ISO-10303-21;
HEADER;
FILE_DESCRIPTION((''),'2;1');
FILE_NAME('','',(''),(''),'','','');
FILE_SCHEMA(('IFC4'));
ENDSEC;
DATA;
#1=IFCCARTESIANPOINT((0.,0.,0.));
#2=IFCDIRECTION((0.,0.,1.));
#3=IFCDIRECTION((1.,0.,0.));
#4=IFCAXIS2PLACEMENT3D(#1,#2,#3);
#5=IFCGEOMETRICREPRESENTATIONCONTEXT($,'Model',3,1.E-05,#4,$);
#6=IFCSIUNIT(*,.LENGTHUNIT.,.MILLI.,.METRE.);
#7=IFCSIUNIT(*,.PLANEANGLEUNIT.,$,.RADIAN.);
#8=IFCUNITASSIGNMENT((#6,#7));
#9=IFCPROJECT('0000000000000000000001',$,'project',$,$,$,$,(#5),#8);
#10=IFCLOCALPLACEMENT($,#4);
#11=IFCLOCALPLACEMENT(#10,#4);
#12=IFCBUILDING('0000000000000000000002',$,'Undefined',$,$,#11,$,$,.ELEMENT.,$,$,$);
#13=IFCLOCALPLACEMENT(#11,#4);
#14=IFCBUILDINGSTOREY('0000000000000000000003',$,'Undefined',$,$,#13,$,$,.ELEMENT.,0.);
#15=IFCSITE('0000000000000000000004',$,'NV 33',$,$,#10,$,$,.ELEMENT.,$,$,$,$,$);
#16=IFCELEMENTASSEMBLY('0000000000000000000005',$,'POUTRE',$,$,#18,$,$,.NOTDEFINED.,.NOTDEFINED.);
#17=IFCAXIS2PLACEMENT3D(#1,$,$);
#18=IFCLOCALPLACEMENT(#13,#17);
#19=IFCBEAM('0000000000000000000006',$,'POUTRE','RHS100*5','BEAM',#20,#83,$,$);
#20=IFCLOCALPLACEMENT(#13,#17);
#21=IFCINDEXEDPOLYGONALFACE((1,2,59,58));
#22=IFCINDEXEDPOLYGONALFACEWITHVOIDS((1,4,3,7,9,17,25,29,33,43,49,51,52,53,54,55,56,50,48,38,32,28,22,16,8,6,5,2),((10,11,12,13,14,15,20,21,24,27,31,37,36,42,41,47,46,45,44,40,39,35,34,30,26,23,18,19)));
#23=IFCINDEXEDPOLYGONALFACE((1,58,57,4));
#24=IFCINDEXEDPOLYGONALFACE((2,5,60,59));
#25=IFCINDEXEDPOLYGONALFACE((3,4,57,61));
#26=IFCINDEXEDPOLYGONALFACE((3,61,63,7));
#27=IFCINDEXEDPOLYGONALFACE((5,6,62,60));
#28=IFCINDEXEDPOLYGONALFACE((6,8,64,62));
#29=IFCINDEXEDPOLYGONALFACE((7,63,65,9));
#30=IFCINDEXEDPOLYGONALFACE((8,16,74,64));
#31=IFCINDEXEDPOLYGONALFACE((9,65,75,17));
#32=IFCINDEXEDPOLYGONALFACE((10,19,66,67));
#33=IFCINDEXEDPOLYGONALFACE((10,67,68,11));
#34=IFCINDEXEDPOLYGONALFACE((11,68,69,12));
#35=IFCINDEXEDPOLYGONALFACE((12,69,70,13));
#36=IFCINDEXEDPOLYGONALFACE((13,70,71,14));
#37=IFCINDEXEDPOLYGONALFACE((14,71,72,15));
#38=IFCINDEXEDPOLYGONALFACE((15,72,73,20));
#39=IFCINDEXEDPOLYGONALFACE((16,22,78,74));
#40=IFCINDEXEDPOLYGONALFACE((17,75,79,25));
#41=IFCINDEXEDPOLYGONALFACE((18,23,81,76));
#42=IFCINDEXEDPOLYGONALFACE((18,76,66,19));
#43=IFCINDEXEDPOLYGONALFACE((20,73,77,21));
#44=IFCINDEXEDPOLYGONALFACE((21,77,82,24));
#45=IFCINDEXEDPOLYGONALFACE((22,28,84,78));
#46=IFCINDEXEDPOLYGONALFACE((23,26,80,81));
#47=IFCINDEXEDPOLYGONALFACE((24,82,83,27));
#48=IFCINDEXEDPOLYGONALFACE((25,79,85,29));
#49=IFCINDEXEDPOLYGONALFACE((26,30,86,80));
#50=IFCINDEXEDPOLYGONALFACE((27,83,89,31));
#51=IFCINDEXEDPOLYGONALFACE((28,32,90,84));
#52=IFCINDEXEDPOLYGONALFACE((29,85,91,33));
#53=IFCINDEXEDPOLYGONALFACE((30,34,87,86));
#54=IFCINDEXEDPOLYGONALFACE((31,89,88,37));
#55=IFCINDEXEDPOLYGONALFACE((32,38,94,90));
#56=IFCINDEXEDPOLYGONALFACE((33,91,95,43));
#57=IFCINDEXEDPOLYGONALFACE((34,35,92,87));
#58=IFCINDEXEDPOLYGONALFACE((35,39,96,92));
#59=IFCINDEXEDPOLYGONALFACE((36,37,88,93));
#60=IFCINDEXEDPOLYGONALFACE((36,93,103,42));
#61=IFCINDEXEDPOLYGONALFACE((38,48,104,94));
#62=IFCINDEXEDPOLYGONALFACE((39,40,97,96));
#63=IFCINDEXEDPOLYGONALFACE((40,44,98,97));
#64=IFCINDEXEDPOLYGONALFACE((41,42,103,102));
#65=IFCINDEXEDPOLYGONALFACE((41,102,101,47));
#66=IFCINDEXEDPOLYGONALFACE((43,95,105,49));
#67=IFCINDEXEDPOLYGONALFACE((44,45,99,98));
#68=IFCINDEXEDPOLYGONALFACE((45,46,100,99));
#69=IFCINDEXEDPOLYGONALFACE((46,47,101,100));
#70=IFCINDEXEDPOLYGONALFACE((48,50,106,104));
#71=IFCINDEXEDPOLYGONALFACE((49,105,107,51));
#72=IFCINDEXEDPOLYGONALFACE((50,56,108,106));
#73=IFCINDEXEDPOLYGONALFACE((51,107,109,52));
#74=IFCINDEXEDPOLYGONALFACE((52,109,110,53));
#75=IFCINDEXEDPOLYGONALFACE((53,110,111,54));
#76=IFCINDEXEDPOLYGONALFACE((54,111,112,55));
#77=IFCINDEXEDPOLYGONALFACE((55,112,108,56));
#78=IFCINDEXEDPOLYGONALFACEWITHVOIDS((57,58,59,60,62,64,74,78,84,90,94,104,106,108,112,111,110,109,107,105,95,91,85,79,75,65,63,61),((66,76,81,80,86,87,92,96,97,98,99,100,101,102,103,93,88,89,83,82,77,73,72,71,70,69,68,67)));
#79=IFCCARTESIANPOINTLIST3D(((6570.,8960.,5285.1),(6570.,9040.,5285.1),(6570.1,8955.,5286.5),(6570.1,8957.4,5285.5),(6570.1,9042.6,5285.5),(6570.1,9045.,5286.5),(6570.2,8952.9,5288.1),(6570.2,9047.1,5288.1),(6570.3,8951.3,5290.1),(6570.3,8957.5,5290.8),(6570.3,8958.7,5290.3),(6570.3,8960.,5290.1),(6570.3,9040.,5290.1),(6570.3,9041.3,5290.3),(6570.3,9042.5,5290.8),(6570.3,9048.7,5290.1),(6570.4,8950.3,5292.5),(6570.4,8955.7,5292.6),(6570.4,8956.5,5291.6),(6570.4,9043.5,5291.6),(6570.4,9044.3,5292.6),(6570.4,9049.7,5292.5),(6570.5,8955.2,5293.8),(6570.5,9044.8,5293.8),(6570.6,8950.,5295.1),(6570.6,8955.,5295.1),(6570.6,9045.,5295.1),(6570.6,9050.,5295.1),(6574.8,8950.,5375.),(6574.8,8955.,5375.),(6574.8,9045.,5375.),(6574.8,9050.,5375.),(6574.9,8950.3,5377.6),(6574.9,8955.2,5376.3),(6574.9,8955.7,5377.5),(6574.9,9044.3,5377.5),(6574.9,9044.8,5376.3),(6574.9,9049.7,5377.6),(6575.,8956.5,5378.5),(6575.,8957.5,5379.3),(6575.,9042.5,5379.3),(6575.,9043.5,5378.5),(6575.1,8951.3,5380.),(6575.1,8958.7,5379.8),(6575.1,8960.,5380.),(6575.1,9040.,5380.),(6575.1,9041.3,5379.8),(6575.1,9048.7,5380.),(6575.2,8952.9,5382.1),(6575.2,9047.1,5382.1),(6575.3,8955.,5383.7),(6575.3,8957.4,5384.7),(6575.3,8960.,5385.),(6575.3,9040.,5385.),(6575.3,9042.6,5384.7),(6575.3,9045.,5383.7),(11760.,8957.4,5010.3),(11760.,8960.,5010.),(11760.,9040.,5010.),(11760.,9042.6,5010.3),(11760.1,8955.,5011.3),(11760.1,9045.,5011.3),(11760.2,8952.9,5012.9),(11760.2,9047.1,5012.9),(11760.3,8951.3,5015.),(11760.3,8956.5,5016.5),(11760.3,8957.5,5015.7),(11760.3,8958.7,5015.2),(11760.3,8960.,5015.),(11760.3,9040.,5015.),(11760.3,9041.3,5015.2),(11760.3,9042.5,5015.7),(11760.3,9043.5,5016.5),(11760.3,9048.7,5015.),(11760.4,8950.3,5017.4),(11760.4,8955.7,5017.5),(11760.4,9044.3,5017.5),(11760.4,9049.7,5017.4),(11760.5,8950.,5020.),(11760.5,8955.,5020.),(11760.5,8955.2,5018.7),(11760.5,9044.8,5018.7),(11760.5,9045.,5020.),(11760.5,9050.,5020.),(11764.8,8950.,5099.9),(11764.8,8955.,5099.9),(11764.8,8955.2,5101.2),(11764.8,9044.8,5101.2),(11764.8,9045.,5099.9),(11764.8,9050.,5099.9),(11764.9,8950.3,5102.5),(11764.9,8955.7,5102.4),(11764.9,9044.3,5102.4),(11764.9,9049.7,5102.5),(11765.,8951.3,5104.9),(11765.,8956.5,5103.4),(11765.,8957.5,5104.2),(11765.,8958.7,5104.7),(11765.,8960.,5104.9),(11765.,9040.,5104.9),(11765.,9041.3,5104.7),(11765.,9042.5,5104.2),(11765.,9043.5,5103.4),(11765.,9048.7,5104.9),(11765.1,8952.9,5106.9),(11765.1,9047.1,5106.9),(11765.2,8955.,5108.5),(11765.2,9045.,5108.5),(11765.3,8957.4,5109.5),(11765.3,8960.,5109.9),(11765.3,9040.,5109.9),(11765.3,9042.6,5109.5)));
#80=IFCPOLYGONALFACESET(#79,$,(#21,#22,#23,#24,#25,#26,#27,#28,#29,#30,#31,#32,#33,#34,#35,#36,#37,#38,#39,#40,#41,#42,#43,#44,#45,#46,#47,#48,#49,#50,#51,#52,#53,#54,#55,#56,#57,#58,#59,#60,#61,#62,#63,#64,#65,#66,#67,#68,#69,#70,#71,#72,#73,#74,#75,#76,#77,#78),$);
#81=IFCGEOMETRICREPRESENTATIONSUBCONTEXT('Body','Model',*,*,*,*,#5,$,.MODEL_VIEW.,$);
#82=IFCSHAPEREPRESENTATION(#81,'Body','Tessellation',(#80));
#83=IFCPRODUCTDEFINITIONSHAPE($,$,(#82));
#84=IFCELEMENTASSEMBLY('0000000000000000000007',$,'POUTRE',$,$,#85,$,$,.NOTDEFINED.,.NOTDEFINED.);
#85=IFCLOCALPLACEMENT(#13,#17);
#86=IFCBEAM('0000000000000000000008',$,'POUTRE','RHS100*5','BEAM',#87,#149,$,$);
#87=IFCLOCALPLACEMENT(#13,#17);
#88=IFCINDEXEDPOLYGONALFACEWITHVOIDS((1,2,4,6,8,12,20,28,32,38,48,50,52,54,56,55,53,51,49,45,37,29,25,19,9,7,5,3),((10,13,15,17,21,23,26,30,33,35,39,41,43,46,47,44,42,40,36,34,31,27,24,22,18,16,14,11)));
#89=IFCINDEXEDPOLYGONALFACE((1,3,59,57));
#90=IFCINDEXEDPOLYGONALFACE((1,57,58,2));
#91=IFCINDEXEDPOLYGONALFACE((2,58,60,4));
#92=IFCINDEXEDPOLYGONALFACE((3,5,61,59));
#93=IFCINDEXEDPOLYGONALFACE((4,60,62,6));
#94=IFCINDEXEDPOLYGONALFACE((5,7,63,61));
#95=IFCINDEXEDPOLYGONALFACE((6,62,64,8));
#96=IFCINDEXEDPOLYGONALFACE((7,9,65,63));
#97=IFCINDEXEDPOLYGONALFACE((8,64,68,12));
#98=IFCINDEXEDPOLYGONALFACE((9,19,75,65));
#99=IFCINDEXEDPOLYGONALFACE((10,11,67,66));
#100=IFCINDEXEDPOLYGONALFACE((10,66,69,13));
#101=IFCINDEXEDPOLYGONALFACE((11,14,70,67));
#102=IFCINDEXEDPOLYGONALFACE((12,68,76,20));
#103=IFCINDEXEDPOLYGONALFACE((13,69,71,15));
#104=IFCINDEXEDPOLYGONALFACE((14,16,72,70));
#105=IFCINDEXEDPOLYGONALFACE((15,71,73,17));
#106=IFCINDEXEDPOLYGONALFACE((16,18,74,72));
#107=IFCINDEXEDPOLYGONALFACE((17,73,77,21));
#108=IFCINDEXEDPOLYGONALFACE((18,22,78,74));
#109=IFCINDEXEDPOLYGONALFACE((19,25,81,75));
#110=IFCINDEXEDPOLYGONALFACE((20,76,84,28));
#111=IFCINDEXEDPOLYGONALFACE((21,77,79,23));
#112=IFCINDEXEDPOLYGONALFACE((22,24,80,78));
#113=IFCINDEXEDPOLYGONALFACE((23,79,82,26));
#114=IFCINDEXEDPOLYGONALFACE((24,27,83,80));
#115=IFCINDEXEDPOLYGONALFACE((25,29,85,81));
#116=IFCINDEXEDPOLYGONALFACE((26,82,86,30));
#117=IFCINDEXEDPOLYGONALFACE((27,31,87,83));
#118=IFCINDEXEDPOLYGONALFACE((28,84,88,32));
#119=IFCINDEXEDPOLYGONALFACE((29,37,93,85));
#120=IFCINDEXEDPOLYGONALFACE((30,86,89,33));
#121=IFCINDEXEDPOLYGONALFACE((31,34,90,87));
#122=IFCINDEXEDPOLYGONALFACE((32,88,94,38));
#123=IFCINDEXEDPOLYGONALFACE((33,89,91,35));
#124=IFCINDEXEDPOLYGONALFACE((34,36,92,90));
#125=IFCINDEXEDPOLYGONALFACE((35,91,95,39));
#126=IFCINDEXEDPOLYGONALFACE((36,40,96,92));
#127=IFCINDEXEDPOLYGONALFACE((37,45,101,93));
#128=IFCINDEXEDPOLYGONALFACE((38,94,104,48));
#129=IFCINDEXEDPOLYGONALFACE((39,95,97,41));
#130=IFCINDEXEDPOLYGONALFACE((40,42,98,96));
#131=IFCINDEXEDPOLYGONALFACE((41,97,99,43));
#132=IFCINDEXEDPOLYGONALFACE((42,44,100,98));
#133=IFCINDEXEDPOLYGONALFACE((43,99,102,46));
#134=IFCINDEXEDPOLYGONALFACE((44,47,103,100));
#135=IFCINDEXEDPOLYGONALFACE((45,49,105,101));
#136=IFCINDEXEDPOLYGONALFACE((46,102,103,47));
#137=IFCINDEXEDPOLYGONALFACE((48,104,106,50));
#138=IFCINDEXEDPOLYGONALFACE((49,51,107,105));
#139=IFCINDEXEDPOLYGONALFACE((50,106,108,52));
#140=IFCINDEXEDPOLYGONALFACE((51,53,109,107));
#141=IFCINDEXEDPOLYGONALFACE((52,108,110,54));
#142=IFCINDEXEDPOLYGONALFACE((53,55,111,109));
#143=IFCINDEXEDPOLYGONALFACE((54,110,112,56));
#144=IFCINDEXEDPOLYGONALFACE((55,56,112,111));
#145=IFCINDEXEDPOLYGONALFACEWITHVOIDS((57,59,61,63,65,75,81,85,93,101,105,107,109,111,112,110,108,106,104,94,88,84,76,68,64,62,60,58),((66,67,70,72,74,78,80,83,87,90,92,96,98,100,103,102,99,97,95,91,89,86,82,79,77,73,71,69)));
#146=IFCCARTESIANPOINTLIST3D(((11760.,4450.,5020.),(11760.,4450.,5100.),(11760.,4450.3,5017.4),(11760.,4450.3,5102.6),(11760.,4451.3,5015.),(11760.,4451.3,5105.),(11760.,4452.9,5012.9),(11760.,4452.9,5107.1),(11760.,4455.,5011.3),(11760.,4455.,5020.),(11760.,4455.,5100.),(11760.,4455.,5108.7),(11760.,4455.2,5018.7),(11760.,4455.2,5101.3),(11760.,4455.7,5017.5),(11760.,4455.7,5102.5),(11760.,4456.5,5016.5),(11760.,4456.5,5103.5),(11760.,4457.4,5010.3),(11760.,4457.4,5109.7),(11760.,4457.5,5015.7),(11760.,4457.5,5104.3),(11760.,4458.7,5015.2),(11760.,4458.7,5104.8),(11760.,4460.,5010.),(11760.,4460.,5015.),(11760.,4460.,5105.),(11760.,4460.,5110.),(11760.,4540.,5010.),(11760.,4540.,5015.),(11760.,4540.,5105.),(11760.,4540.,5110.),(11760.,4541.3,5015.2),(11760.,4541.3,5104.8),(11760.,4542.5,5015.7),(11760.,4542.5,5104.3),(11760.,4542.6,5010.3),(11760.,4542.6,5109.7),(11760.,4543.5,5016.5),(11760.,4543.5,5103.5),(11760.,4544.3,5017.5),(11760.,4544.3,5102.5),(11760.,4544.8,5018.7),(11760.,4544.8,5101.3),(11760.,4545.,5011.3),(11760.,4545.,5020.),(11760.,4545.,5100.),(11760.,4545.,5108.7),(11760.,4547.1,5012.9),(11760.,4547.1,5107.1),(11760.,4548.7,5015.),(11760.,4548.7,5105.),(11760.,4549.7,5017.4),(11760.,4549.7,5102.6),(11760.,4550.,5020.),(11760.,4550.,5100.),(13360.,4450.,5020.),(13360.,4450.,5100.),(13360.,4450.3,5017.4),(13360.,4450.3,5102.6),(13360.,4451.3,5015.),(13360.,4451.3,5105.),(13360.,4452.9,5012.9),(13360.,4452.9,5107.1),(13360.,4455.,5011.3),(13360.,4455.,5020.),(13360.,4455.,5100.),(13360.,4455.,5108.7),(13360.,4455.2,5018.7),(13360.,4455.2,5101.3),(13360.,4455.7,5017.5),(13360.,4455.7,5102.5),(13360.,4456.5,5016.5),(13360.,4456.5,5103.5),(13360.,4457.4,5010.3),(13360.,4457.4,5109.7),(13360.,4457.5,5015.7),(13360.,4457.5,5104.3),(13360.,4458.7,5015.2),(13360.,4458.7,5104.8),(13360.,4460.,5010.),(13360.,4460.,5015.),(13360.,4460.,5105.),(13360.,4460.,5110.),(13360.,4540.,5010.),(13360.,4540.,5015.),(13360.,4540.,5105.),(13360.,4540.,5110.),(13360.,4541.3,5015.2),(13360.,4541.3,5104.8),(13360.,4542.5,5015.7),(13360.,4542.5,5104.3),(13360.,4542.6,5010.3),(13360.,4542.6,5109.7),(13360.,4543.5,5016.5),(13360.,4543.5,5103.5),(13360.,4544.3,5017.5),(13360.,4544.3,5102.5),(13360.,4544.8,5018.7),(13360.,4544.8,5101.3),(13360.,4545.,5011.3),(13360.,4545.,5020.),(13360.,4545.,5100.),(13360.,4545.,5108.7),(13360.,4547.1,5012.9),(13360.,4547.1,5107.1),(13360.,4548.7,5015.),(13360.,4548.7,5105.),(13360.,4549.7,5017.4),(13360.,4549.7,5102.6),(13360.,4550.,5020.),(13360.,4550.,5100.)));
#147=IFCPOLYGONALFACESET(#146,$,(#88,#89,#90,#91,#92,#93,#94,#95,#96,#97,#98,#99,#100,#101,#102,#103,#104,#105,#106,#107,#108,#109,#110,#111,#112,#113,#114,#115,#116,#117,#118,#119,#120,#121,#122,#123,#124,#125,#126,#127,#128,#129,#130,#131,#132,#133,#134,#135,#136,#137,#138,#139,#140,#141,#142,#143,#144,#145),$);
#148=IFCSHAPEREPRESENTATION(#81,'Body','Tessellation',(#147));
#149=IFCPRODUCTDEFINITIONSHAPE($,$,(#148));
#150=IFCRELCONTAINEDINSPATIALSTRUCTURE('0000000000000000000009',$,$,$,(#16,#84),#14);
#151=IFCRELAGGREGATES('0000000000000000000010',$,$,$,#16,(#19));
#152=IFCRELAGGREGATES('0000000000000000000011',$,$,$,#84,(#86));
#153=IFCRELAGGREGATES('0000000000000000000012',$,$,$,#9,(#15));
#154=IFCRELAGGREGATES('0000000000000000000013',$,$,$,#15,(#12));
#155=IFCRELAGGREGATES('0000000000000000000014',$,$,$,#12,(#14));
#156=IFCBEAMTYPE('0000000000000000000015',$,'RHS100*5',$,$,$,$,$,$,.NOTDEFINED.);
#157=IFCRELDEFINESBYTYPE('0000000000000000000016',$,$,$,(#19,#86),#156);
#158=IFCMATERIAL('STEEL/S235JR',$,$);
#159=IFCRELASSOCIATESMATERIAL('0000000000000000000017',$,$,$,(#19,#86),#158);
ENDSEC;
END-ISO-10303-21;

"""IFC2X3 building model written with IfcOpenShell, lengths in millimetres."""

from ifc_helpers import new_model, si_unit, frame, origin_with_axes, origin_2d_with_axis, place, context, subcontext, project, spatial, hollow_rectangle, extrude, boolean, halfspace, material, type_object, element, aggregate, save


model = new_model("IFC2X3")

# Units and contexts
model_context = context("Model", 3, precision=1e-05, world=origin_with_axes())
body_context = subcontext(model_context, "Body", "Model", "MODEL_VIEW")
ifc_project = project(units=[si_unit("LENGTHUNIT", "METRE", prefix="MILLI"), si_unit("PLANEANGLEUNIT", "RADIAN")], contexts=[model_context])

# Site, building, storey
site_placement = place(None, origin_with_axes())
site = spatial("IfcSite", under=ifc_project, at=site_placement, Name="NV 33", CompositionType="ELEMENT")
building_placement = place(site_placement, origin_with_axes())
building = spatial("IfcBuilding", under=site, at=building_placement, Name="Undefined", CompositionType="ELEMENT")
storey_placement = place(building_placement, origin_with_axes())
storey = spatial("IfcBuildingStorey", under=building, at=storey_placement, Name="Undefined", CompositionType="ELEMENT", Elevation=0.0)

# Shared definitions
ifc_material_1 = material(Name="STEEL/S235JR")

# Element assemblies, beams
assembly_1_placement = place(storey_placement, origin_with_axes())
assembly_1 = element("IfcElementAssembly", 1, at=assembly_1_placement, inside=storey, Name="POUTRE", AssemblyPlace="NOTDEFINED", PredefinedType="NOTDEFINED")
beam_type_1 = type_object("IfcBeamType", Name="RHS100*5", PredefinedType="NOTDEFINED")
beam_1_placement = place(assembly_1_placement, frame((11762.6, 9000.0, 5059.9), z_axis=(-0.052941, 0.0, -0.998598), x_axis=(-0.998598, 0.0, 0.052941)))
solid_1 = boolean("DIFFERENCE", boolean("DIFFERENCE", extrude(hollow_rectangle(XDim=100.0, YDim=100.0, WallThickness=5.0, InnerFilletRadius=5.0, OuterFilletRadius=10.0, at=origin_2d_with_axis()), frame((5142.7, 0.0, -2.9), z_axis=(0.994395, 0.0, 0.105733), x_axis=(0.0, 1.0, 0.0)), (0.0, 0.0, 1.0), 5197.2), extrude(hollow_rectangle(XDim=100.0, YDim=100.0, WallThickness=5.0, InnerFilletRadius=5.0, OuterFilletRadius=10.0, at=origin_2d_with_axis()), frame((10308.2, 0.0, 546.4), z_axis=(0.998598, 0.0, 0.052941), x_axis=(-0.052941, 0.0, 0.998598)), (0.0, 0.0, 1.0), 1600.0)), halfspace(frame((5172.5, 50.0, -50.0), z_axis=(-0.998598, 0.0, -0.052941), x_axis=(-0.052941, 0.0, 0.998598)), False))
beam_1 = element("IfcBeam", 2, at=beam_1_placement, type_object=beam_type_1, material=ifc_material_1, Name="POUTRE", Description="RHS100*5", ObjectType="BEAM", context=body_context, shape_type="CSG", body=[
    boolean("DIFFERENCE", boolean("DIFFERENCE", boolean("DIFFERENCE", extrude(hollow_rectangle(XDim=100.0, YDim=100.0, WallThickness=5.0, InnerFilletRadius=5.0, OuterFilletRadius=10.0, at=origin_2d_with_axis()), frame((5197.2, 0.0, 0.0), z_axis=(-1.0, 0.0, 0.0), x_axis=(0.0, -1.0, 0.0)), (0.0, 0.0, 1.0), 5197.2), solid_1), extrude(hollow_rectangle(XDim=100.0, YDim=100.0, WallThickness=5.0, InnerFilletRadius=5.0, OuterFilletRadius=10.0, at=origin_2d_with_axis()), frame((2.6, 0.0, 0.1), z_axis=(-0.998598, 0.0, -0.052941), x_axis=(0.052941, 0.0, -0.998598)), (0.0, 0.0, 1.0), 1600.0)), halfspace(frame((5172.5, 50.0, -50.0), z_axis=(0.998598, 0.0, 0.052941), x_axis=(0.0, -1.0, 0.0)), False)),
])
aggregate(assembly_1, [beam_1])
assembly_2_placement = place(storey_placement, origin_with_axes())
assembly_2 = element("IfcElementAssembly", 3, at=assembly_2_placement, inside=storey, Name="POUTRE", AssemblyPlace="NOTDEFINED", PredefinedType="NOTDEFINED")
beam_2_placement = place(assembly_2_placement, frame((13360.0, 4500.0, 5060.0), z_axis=(0.0, -1.0, 0.0), x_axis=(-1.0, 0.0, 0.0)))
beam_2 = element("IfcBeam", 4, at=beam_2_placement, type_object=beam_type_1, material=ifc_material_1, Name="POUTRE", Description="RHS100*5", ObjectType="BEAM", context=body_context, shape_type="SweptSolid", body=[
    extrude(hollow_rectangle(XDim=100.0, YDim=100.0, WallThickness=5.0, InnerFilletRadius=5.0, OuterFilletRadius=10.0, at=origin_2d_with_axis()), frame((1600.0, 0.0, 0.0), z_axis=(-1.0, 0.0, 0.0), x_axis=(0.0, -1.0, 0.0)), (0.0, 0.0, 1.0), 1600.0),
])
aggregate(assembly_2, [beam_2])

save(model, "model.ifc")
